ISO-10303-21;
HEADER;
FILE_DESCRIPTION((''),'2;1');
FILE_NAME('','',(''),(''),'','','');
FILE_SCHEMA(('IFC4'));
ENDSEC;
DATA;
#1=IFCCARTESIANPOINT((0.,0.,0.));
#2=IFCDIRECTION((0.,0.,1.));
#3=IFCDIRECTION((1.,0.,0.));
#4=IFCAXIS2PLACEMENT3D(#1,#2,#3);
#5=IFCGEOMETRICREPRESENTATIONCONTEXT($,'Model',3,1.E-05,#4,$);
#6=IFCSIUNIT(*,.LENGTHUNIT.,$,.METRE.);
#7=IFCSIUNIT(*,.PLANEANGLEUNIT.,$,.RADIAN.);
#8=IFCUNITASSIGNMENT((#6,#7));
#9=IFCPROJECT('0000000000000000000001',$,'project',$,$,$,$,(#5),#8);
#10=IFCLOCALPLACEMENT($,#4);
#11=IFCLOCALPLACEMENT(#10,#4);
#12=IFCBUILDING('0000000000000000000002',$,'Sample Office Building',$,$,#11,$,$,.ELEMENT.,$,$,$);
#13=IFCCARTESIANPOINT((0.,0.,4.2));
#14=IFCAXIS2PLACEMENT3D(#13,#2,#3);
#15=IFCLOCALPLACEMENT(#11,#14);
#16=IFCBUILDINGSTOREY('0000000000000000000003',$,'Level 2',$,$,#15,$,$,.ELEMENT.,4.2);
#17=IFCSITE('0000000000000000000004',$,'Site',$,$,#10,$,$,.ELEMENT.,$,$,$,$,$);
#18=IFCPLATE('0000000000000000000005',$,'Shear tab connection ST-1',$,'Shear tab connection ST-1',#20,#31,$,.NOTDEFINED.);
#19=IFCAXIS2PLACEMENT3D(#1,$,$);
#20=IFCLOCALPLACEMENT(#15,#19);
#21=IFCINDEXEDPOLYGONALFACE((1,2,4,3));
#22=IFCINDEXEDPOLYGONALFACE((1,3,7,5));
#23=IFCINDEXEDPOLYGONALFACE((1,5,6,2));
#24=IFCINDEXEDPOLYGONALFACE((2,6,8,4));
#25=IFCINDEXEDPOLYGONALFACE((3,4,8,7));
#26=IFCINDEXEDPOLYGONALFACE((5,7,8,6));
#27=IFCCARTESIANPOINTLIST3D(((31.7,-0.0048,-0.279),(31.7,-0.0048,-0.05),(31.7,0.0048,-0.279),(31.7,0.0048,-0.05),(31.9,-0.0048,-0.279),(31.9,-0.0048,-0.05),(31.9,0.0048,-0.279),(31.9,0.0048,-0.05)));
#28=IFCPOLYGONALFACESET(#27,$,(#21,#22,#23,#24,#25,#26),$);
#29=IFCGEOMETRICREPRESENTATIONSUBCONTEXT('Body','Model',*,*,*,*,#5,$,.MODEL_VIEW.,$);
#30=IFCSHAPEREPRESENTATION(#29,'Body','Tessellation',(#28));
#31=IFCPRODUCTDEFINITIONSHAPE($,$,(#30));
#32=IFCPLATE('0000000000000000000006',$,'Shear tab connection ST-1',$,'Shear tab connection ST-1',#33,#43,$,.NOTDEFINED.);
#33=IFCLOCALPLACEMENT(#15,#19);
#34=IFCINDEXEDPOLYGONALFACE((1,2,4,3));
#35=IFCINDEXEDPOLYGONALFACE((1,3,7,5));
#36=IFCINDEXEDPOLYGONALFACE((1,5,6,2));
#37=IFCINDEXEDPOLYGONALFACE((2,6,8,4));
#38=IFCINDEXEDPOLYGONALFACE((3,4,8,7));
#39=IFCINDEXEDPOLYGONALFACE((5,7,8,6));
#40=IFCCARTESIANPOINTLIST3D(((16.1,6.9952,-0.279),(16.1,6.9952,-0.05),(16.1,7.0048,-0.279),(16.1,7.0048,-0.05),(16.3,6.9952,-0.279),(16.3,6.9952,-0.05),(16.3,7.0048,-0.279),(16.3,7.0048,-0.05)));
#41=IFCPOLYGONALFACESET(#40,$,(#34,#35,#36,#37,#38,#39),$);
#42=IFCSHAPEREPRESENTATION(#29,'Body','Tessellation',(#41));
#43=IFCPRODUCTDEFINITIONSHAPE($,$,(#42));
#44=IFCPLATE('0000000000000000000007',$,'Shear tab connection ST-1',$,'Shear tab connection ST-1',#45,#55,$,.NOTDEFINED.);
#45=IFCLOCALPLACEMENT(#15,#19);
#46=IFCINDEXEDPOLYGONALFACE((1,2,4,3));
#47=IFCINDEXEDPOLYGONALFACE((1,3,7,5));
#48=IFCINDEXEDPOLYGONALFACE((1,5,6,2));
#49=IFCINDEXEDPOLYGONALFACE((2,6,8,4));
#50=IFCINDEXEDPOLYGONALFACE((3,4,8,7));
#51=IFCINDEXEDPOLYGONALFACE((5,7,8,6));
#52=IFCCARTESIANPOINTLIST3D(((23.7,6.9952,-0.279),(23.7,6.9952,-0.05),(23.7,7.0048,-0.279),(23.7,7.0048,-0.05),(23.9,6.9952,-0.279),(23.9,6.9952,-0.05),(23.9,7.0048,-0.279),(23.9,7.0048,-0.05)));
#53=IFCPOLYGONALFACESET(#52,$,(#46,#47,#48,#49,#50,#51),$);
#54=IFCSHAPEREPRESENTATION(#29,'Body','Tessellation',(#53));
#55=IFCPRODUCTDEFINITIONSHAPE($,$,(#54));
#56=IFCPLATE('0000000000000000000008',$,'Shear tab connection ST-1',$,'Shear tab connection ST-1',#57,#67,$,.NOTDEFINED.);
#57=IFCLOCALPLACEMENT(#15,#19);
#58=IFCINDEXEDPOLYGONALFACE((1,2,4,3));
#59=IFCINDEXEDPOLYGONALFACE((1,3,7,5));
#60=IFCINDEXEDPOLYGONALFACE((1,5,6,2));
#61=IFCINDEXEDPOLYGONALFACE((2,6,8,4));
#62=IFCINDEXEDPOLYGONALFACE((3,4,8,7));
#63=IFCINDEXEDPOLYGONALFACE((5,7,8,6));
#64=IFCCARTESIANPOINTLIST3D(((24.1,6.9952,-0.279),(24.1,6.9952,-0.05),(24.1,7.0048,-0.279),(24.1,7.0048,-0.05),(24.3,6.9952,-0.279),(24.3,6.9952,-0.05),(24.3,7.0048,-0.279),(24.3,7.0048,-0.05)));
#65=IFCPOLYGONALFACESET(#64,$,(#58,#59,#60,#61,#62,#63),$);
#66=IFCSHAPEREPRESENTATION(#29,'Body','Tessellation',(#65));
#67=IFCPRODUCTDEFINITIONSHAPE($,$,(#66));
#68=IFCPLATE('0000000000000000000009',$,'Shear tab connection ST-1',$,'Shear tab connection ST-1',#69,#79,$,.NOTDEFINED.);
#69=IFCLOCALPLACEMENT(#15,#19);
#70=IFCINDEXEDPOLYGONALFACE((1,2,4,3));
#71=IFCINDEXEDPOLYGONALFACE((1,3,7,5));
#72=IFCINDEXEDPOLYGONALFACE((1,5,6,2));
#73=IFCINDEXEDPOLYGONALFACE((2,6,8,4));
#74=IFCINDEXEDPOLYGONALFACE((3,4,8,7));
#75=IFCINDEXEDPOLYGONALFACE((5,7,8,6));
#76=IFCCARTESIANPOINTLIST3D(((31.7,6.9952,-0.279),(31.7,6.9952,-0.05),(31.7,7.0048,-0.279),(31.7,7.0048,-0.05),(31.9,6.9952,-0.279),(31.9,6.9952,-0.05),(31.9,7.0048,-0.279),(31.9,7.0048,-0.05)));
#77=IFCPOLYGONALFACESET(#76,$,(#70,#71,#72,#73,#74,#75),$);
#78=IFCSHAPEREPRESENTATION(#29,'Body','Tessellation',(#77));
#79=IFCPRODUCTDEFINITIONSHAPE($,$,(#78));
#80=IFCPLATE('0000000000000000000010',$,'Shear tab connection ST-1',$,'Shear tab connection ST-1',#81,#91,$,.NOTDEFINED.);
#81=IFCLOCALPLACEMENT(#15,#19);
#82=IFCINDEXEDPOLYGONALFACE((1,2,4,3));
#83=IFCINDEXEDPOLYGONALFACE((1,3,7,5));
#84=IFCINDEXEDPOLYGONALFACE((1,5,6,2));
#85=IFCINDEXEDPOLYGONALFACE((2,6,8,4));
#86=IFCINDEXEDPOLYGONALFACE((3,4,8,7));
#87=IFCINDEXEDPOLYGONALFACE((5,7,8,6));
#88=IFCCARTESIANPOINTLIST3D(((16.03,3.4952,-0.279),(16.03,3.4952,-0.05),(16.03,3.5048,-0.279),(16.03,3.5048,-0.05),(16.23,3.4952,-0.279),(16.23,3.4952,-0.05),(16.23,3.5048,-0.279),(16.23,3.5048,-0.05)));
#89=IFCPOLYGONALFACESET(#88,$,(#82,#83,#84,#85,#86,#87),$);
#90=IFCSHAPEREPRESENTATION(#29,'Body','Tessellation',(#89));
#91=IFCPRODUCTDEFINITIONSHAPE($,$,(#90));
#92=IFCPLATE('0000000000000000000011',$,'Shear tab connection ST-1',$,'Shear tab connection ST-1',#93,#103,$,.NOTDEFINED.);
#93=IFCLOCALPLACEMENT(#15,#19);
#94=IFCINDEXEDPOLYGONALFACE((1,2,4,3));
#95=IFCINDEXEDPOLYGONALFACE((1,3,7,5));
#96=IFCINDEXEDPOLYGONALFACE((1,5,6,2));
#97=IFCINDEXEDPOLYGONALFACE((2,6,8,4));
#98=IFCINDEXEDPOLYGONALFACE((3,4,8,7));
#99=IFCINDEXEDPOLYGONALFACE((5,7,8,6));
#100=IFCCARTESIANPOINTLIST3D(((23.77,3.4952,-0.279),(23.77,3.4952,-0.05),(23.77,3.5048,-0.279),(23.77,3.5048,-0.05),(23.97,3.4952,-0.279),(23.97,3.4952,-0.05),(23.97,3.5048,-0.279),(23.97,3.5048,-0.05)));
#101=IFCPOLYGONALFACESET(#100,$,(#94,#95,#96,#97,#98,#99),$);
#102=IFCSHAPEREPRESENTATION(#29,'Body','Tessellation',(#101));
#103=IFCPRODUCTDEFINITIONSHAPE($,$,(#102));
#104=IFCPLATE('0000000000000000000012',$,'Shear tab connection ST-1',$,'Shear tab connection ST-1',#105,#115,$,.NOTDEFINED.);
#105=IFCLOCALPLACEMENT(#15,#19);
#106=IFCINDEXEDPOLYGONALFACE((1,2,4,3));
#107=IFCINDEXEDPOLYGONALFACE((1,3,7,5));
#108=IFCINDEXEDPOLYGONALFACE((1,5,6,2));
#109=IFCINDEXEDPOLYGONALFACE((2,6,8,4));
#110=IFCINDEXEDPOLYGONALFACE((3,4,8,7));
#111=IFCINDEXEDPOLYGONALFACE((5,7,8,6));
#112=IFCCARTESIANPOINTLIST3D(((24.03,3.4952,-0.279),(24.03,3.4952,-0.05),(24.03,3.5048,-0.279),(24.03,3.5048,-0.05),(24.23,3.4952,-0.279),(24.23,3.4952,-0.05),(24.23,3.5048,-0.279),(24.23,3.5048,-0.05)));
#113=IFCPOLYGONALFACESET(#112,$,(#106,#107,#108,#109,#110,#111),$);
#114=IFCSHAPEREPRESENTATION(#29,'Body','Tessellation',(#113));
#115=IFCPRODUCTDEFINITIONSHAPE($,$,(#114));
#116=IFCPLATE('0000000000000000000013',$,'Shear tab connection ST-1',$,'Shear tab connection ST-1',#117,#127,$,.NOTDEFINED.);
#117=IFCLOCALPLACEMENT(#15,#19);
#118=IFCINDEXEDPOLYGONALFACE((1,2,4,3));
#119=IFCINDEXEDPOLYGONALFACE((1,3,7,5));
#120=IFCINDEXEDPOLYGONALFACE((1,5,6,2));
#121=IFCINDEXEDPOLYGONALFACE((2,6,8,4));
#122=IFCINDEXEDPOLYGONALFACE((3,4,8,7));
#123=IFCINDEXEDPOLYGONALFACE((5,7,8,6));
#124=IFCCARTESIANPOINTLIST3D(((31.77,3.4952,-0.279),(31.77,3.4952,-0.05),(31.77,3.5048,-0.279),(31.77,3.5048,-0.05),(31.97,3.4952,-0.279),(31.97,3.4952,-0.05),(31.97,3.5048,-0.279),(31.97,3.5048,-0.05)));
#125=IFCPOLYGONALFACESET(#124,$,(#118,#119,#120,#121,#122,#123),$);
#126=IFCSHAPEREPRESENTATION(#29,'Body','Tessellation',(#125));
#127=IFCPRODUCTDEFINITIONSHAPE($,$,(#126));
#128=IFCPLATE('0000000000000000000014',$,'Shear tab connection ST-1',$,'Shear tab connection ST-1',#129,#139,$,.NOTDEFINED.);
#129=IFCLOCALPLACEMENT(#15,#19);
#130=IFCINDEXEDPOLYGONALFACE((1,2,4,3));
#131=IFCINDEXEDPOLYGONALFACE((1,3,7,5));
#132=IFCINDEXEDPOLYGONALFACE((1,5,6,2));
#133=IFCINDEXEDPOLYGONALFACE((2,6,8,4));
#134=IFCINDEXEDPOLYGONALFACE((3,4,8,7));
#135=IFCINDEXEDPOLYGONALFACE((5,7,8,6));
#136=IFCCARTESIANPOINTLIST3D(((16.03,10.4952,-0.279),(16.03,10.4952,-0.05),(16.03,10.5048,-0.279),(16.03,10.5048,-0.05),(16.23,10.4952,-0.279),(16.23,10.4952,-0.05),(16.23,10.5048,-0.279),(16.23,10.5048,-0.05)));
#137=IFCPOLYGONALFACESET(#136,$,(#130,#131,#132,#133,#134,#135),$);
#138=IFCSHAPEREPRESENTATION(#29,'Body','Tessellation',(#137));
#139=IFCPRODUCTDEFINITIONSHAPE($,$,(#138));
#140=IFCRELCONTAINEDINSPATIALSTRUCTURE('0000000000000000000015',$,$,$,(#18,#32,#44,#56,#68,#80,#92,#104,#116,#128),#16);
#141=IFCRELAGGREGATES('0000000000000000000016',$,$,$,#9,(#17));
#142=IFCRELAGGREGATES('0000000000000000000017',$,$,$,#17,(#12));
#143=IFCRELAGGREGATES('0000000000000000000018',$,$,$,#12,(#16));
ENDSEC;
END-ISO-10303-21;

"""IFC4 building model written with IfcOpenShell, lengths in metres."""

from ifc_helpers import new_model, si_unit, frame, origin_with_axes, place, context, subcontext, project, spatial, rectangle, extrude, element, save


model = new_model("IFC4")

# Units and contexts
model_context = context("Model", 3, precision=1e-05, world=origin_with_axes())
body_context = subcontext(model_context, "Body", "Model", "MODEL_VIEW")
ifc_project = project(units=[si_unit("LENGTHUNIT", "METRE"), si_unit("PLANEANGLEUNIT", "RADIAN")], contexts=[model_context])

# Site, building, storey
site_placement = place(None, origin_with_axes())
site = spatial("IfcSite", under=ifc_project, at=site_placement, Name="Site", CompositionType="ELEMENT")
building_placement = place(site_placement, origin_with_axes())
building = spatial("IfcBuilding", under=site, at=building_placement, Name="Sample Office Building", CompositionType="ELEMENT")
storey_placement = place(building_placement, frame((0.0, 0.0, 4.2), z_axis=(0.0, 0.0, 1.0), x_axis=(1.0, 0.0, 0.0)))
storey = spatial("IfcBuildingStorey", under=building, at=storey_placement, Name="Level 2", CompositionType="ELEMENT", Elevation=4.2)

# Plates
for number, where, z_axis, x_axis, name in (
    (1, (31.8, 0.0, 3.921), (0.0, 0.0, 1.0), (1.0, 0.0, 0.0), "Shear tab connection ST-1"),
):
    element("IfcPlate", number, at=place(None, frame(where, z_axis=z_axis, x_axis=x_axis)), inside=storey, Name=name, ObjectType="Shear tab connection ST-1", PredefinedType="NOTDEFINED", context=body_context, shape_type="SweptSolid", body=[
        extrude(rectangle(XDim=0.2, YDim=0.0095), None, (0.0, 0.0, 1.0), 0.229),
    ])
for number, where, z_axis, x_axis, name in (
    (2, (16.2, 7.0, 3.921), (0.0, 0.0, 1.0), (1.0, 0.0, 0.0), "Shear tab connection ST-1"),
    (3, (23.8, 7.0, 3.921), (0.0, 0.0, 1.0), (1.0, 0.0, 0.0), "Shear tab connection ST-1"),
    (4, (24.2, 7.0, 3.921), (0.0, 0.0, 1.0), (1.0, 0.0, 0.0), "Shear tab connection ST-1"),
    (5, (31.8, 7.0, 3.921), (0.0, 0.0, 1.0), (1.0, 0.0, 0.0), "Shear tab connection ST-1"),
):
    element("IfcPlate", number, at=place(None, frame(where, z_axis=z_axis, x_axis=x_axis)), inside=storey, Name=name, ObjectType="Shear tab connection ST-1", PredefinedType="NOTDEFINED", context=body_context, shape_type="SweptSolid", body=[
        extrude(rectangle(XDim=0.2, YDim=0.0095), None, (0.0, 0.0, 1.0), 0.229),
    ])
for number, where, z_axis, x_axis, name in (
    (6, (16.13, 3.5, 3.921), (0.0, 0.0, 1.0), (1.0, 0.0, 0.0), "Shear tab connection ST-1"),
    (7, (23.87, 3.5, 3.921), (0.0, 0.0, 1.0), (1.0, 0.0, 0.0), "Shear tab connection ST-1"),
    (8, (24.13, 3.5, 3.921), (0.0, 0.0, 1.0), (1.0, 0.0, 0.0), "Shear tab connection ST-1"),
    (9, (31.87, 3.5, 3.921), (0.0, 0.0, 1.0), (1.0, 0.0, 0.0), "Shear tab connection ST-1"),
):
    element("IfcPlate", number, at=place(None, frame(where, z_axis=z_axis, x_axis=x_axis)), inside=storey, Name=name, ObjectType="Shear tab connection ST-1", PredefinedType="NOTDEFINED", context=body_context, shape_type="SweptSolid", body=[
        extrude(rectangle(XDim=0.2, YDim=0.0095), None, (0.0, 0.0, 1.0), 0.229),
    ])
plate_1_placement = place(None, frame((16.13, 10.5, 3.921), z_axis=(0.0, 0.0, 1.0), x_axis=(1.0, 0.0, 0.0)))
element("IfcPlate", 10, at=plate_1_placement, inside=storey, Name="Shear tab connection ST-1", ObjectType="Shear tab connection ST-1", PredefinedType="NOTDEFINED", context=body_context, shape_type="SweptSolid", body=[
    extrude(rectangle(XDim=0.2, YDim=0.0095), None, (0.0, 0.0, 1.0), 0.229),
])

save(model, "model.ifc")
